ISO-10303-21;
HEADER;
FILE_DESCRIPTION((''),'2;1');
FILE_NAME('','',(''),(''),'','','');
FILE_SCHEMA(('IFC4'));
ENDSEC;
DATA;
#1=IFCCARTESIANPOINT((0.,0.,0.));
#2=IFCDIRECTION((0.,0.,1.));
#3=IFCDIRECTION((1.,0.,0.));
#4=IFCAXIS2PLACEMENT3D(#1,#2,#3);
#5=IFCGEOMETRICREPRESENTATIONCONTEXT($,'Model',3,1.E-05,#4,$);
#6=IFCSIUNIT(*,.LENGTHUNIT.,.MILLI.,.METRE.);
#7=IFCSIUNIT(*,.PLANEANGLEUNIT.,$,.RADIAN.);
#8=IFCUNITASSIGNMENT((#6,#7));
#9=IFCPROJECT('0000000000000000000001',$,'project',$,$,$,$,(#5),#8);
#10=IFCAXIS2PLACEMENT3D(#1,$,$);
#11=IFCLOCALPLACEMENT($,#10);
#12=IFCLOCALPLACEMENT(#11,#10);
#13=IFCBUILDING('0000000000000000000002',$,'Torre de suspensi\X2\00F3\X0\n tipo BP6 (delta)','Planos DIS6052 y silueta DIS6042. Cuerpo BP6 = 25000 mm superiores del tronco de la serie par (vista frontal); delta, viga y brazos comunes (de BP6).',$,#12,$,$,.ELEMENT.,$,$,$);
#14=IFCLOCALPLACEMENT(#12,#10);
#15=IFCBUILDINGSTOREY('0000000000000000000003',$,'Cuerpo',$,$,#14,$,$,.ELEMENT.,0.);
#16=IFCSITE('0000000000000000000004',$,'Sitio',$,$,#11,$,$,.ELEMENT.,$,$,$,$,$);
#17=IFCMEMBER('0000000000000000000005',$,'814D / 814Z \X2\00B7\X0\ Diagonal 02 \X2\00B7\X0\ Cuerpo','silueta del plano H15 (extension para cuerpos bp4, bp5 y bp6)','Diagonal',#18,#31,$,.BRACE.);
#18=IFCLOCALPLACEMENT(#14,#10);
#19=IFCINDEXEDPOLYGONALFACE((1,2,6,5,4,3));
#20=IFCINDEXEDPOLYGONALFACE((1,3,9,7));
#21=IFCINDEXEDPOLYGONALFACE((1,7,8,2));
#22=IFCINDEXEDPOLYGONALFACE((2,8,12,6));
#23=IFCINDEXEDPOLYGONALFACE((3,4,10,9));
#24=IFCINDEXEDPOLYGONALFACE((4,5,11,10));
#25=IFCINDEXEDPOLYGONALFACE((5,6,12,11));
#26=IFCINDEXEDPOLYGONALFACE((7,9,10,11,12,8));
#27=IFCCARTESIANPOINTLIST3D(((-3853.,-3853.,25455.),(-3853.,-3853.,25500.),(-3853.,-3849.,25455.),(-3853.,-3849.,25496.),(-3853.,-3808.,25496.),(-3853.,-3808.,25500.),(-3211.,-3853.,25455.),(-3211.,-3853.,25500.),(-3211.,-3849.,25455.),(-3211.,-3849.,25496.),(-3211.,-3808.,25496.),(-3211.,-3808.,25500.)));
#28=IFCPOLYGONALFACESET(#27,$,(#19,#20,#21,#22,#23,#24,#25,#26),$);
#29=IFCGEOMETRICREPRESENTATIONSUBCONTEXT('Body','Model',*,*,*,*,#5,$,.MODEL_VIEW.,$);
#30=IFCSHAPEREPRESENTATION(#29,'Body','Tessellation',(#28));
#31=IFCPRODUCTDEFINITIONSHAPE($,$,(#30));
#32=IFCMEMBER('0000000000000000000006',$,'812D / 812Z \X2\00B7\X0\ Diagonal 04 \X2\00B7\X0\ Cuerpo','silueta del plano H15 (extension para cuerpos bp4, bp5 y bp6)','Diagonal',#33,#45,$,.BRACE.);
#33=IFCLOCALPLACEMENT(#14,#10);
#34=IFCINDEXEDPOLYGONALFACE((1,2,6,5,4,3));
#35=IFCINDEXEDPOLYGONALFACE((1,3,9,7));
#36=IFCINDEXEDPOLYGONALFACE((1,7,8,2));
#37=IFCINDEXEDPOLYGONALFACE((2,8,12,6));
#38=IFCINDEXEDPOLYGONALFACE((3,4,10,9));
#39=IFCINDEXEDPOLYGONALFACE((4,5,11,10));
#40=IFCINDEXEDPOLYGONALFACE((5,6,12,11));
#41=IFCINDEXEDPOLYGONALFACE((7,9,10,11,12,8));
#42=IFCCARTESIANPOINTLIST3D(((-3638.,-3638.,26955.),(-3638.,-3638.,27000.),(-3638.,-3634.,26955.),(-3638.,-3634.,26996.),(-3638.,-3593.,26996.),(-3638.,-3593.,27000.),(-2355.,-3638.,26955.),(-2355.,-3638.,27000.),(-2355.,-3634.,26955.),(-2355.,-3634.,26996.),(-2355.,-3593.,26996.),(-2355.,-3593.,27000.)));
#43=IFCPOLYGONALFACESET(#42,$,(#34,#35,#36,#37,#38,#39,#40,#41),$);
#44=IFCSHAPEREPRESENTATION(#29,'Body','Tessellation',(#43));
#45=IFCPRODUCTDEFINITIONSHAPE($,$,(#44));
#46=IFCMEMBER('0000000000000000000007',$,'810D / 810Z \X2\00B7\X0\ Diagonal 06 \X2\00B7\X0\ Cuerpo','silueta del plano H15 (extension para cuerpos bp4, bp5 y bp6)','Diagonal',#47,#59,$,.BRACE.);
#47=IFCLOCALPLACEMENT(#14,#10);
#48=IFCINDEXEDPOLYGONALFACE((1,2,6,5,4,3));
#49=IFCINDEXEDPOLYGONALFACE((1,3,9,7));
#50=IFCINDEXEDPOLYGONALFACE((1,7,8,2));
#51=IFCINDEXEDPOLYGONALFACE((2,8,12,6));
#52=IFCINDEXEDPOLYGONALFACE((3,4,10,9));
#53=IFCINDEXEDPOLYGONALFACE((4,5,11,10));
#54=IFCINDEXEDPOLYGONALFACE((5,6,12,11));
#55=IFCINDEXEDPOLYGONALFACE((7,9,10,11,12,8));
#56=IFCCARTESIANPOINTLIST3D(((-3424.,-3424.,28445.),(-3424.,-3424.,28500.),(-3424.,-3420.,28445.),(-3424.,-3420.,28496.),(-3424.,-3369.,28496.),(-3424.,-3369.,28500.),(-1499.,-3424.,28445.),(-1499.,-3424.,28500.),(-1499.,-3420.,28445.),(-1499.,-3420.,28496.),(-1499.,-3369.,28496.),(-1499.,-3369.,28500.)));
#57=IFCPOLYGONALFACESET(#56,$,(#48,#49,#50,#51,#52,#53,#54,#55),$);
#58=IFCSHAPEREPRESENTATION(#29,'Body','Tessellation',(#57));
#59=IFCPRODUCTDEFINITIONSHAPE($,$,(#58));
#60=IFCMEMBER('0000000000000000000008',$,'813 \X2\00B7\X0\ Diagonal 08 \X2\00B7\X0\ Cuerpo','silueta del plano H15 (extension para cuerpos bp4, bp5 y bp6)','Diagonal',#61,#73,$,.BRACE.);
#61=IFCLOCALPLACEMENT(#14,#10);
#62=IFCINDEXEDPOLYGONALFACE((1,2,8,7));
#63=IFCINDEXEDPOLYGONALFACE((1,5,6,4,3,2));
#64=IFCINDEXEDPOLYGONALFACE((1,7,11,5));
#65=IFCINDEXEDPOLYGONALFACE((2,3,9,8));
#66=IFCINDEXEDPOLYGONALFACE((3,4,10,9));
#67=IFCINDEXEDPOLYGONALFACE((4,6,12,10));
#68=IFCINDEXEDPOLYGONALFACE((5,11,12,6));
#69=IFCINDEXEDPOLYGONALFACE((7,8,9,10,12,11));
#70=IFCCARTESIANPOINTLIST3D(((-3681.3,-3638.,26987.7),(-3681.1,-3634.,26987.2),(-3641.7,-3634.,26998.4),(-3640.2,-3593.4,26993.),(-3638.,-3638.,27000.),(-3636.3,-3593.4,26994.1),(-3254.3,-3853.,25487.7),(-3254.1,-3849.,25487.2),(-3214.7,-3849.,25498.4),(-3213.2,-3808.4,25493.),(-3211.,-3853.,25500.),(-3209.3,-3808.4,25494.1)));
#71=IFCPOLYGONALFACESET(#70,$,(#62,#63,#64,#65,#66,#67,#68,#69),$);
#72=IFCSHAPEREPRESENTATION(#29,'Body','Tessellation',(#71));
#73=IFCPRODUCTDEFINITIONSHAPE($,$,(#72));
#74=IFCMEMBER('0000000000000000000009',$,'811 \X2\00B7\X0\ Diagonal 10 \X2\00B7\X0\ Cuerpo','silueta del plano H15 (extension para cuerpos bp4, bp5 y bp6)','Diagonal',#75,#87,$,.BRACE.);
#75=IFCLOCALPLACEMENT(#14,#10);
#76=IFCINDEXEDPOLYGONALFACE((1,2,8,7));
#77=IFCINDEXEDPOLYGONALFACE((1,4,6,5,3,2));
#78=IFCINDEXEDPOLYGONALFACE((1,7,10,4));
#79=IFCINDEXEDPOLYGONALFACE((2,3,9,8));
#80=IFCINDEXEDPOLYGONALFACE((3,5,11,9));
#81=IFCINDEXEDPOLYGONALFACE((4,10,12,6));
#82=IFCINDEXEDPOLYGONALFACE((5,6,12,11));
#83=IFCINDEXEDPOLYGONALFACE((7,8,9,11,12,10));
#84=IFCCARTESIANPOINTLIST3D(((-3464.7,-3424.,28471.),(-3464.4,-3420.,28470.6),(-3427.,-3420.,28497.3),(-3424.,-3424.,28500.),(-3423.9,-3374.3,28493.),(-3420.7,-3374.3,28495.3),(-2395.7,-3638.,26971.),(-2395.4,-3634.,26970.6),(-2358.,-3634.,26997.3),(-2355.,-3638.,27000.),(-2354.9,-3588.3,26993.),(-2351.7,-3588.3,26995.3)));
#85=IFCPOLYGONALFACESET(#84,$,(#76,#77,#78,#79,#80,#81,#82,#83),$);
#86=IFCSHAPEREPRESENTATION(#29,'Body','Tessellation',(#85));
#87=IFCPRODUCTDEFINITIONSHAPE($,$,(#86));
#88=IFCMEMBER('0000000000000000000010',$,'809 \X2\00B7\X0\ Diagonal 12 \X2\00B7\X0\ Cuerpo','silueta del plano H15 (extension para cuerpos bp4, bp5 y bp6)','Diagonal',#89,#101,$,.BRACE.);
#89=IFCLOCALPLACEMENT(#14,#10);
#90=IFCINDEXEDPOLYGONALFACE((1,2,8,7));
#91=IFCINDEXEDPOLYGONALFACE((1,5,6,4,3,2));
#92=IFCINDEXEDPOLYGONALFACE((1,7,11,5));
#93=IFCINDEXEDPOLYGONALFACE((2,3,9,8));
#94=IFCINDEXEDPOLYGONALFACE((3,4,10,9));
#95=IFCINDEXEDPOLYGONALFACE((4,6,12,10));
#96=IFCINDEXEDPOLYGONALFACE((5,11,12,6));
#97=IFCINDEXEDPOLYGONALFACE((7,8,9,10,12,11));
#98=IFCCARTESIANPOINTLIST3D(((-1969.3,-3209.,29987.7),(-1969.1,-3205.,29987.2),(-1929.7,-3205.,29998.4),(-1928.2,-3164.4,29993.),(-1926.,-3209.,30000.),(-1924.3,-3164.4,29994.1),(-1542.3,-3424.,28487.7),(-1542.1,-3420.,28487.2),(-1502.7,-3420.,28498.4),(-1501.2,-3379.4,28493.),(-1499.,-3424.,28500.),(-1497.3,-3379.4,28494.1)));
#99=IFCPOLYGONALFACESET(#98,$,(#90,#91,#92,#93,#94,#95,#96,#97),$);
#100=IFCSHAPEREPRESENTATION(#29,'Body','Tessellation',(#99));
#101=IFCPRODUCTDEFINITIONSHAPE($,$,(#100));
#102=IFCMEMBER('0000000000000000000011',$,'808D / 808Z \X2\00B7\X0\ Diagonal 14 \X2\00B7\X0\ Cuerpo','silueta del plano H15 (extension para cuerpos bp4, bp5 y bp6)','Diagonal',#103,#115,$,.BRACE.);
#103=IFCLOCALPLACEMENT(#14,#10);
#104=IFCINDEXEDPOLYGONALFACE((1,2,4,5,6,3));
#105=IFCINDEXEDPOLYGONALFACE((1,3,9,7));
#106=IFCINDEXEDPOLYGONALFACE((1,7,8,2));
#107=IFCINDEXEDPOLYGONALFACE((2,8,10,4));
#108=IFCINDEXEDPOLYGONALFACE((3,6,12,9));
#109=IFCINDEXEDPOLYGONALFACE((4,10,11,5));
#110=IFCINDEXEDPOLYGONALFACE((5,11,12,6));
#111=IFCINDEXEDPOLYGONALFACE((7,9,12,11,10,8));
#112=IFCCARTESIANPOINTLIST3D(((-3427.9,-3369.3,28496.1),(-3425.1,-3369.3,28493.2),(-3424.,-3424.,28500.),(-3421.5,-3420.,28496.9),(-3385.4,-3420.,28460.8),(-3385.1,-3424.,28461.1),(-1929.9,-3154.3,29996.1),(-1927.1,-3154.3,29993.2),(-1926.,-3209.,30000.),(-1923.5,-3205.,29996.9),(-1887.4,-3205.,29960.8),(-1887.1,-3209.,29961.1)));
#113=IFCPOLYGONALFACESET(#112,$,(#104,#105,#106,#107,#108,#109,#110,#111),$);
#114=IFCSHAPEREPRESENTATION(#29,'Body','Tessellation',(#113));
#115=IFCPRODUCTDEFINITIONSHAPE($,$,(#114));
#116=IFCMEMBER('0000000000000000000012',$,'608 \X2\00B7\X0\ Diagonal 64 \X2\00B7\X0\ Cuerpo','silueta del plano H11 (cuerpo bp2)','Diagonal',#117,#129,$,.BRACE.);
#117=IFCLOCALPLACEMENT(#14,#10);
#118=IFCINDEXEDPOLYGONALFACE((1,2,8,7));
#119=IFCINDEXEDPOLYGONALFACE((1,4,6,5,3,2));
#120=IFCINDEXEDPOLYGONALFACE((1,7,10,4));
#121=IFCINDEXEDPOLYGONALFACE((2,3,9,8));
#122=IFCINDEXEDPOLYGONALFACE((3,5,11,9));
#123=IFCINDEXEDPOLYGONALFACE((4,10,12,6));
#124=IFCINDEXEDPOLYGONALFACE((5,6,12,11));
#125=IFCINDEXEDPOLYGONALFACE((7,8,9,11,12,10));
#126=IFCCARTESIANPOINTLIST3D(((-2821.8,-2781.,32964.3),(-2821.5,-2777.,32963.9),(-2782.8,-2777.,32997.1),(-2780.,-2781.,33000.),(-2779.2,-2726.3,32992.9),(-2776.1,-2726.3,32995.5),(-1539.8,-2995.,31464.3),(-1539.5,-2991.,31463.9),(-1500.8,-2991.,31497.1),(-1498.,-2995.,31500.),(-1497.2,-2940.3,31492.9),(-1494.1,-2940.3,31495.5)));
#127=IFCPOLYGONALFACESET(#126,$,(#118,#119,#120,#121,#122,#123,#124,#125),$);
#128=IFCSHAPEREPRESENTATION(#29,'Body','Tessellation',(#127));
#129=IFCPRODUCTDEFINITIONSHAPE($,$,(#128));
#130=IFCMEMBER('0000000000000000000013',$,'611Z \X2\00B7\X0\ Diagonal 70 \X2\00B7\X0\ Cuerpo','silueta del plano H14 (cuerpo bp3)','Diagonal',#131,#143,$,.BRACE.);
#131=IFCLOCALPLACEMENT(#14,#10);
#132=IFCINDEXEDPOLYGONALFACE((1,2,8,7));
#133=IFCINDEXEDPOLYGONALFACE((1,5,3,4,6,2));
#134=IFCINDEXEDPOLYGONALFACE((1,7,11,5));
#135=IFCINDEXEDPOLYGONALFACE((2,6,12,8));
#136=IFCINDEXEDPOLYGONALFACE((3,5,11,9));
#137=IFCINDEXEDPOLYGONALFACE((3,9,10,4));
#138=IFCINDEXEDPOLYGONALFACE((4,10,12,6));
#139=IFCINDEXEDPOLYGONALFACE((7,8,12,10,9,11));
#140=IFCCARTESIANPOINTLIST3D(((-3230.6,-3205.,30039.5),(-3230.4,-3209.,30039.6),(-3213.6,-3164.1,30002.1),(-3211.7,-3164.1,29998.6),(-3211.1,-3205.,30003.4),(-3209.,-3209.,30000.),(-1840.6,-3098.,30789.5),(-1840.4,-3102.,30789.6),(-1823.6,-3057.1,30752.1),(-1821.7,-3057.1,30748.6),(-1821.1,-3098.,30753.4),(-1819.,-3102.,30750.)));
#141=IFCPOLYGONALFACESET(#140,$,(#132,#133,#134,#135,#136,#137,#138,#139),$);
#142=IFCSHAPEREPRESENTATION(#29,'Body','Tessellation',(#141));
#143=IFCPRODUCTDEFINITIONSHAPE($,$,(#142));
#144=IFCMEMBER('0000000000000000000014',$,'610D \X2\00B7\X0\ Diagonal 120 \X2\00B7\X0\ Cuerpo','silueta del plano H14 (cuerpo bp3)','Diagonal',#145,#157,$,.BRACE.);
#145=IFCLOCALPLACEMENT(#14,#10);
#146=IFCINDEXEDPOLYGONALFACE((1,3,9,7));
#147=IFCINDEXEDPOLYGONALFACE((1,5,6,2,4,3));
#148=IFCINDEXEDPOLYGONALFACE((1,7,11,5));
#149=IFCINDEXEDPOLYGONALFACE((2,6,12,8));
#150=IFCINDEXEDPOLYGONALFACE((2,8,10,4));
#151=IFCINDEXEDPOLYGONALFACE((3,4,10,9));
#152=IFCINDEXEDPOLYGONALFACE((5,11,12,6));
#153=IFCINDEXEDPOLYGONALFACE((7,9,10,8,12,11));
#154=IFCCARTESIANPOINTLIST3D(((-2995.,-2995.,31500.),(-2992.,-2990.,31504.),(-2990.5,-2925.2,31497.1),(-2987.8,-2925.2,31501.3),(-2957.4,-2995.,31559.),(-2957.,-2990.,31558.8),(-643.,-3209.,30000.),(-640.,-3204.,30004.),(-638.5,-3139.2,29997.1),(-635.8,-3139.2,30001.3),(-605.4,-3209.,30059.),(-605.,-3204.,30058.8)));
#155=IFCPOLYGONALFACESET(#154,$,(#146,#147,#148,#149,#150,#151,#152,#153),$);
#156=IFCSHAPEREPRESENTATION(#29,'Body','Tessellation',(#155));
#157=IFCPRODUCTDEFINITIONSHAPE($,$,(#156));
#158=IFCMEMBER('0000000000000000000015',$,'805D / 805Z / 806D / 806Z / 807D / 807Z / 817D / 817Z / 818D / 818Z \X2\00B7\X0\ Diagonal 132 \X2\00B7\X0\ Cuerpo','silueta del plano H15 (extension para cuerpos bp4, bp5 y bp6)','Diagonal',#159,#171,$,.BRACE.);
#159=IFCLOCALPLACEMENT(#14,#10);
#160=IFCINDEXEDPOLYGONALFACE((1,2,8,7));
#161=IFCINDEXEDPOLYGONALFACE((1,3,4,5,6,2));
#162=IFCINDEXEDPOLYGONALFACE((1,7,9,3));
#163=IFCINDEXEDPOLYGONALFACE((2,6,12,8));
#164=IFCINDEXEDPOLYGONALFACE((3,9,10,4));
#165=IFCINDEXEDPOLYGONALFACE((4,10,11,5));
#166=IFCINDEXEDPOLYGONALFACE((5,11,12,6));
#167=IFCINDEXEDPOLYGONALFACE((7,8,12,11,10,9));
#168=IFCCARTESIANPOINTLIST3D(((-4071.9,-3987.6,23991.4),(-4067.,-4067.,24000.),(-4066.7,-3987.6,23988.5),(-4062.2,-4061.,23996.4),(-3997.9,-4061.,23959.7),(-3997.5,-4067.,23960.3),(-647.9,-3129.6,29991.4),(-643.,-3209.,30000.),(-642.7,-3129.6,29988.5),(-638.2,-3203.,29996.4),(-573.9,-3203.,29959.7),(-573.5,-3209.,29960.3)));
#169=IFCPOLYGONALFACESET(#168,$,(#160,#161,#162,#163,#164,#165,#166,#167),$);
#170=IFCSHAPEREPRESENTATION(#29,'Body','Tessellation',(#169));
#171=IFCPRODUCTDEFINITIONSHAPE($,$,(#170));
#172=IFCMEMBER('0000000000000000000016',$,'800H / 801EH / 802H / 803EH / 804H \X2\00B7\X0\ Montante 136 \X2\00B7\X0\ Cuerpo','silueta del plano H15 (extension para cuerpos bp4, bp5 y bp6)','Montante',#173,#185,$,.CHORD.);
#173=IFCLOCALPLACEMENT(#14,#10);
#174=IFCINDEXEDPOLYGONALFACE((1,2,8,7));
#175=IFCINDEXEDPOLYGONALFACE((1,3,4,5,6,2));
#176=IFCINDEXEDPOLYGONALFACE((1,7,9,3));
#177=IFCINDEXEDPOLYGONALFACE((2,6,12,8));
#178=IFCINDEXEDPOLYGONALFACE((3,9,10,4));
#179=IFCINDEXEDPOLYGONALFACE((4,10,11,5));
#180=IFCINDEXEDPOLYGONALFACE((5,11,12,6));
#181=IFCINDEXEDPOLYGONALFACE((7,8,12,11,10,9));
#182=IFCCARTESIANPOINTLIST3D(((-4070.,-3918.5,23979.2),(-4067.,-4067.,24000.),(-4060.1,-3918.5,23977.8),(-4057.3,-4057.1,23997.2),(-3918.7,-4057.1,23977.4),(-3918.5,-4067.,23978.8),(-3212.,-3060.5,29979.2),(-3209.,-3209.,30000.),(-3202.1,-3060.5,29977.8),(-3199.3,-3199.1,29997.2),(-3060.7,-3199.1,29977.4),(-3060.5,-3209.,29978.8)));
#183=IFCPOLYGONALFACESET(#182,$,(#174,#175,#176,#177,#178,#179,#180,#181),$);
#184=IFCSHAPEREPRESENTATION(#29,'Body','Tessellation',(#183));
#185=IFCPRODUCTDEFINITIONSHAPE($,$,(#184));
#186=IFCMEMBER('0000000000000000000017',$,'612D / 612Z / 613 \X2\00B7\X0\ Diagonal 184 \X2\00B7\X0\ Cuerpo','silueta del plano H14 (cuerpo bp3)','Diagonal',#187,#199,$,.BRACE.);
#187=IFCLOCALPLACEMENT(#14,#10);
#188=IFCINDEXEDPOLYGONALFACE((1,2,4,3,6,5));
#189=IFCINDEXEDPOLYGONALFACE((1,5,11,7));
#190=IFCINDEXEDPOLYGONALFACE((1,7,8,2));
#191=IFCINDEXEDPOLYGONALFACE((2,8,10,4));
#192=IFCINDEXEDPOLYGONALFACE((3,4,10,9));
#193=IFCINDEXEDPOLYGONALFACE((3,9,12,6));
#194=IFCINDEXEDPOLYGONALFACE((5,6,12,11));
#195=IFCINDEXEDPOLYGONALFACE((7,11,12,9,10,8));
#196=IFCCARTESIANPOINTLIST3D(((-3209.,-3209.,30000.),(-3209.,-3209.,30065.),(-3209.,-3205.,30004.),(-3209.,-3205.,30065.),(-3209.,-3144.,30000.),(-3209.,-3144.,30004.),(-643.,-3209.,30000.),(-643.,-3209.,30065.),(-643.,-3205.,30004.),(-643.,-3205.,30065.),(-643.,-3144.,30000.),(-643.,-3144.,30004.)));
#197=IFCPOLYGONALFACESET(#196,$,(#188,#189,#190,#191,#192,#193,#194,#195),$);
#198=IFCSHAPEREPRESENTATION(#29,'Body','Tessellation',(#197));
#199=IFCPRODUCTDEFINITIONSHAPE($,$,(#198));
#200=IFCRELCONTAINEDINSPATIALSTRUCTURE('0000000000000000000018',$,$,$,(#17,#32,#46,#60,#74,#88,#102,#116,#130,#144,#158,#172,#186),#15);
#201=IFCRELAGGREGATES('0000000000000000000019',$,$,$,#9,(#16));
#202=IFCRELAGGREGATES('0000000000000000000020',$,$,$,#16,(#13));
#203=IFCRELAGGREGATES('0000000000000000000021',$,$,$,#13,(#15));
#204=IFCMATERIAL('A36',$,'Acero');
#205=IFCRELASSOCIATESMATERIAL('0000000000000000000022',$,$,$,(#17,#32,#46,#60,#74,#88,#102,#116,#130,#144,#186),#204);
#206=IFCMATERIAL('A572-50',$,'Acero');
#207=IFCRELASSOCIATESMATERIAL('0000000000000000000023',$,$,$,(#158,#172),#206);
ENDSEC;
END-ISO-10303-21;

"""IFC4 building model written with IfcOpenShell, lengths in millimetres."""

from ifc_helpers import new_model, si_unit, frame, frame_2d, origin, origin_with_axes, place, context, subcontext, project, spatial, l_section, extrude, material, element, save


model = new_model("IFC4")

# Units and contexts
model_context = context("Model", 3, precision=1e-05, world=origin_with_axes())
body_context = subcontext(model_context, "Body", "Model", "MODEL_VIEW")
ifc_project = project(units=[si_unit("LENGTHUNIT", "METRE", prefix="MILLI"), si_unit("PLANEANGLEUNIT", "RADIAN")], contexts=[model_context])

# Site, building, storey
site_placement = place(None, origin())
site = spatial("IfcSite", under=ifc_project, at=site_placement, Name="Sitio", CompositionType="ELEMENT")
building_placement = place(site_placement, origin())
building = spatial("IfcBuilding", under=site, at=building_placement, Name="Torre de suspensión tipo BP6 (delta)", Description="Planos DIS6052 y silueta DIS6042. Cuerpo BP6 = 25000 mm superiores del tronco de la serie par (vista frontal); delta, viga y brazos comunes (de BP6).", CompositionType="ELEMENT")
storey_placement = place(building_placement, origin())
storey = spatial("IfcBuildingStorey", under=building, at=storey_placement, Name="Cuerpo", CompositionType="ELEMENT", Elevation=0.0)

# Members
ifc_material_1 = material(Name="A36", Category="Acero")
member_1_placement = place(storey_placement, frame((-3211.0, -3853.0, 25500.0), z_axis=(-1.0, 0.0, 0.0), x_axis=(0.0, 1.0, 0.0)))
element("IfcMember", 1, at=member_1_placement, inside=storey, material=ifc_material_1, Name="814D / 814Z · Diagonal 02 · Cuerpo", Description="silueta del plano H15 (extension para cuerpos bp4, bp5 y bp6)", ObjectType="Diagonal", PredefinedType="BRACE", context=body_context, shape_type="SweptSolid", body=[
    extrude(l_section(Depth=45.0, Width=45.0, Thickness=4.0, at=frame_2d((22.5, 22.5))), None, (0.0, 0.0, 1.0), 642.0),
])
member_2_placement = place(storey_placement, frame((-2355.0, -3638.0, 27000.0), z_axis=(-1.0, 0.0, 0.0), x_axis=(0.0, 1.0, 0.0)))
element("IfcMember", 2, at=member_2_placement, inside=storey, material=ifc_material_1, Name="812D / 812Z · Diagonal 04 · Cuerpo", Description="silueta del plano H15 (extension para cuerpos bp4, bp5 y bp6)", ObjectType="Diagonal", PredefinedType="BRACE", context=body_context, shape_type="SweptSolid", body=[
    extrude(l_section(Depth=45.0, Width=45.0, Thickness=4.0, at=frame_2d((22.5, 22.5))), None, (0.0, 0.0, 1.0), 1283.0),
])
member_3_placement = place(storey_placement, frame((-1499.0, -3424.0, 28500.0), z_axis=(-1.0, 0.0, 0.0), x_axis=(0.0, 1.0, 0.0)))
element("IfcMember", 3, at=member_3_placement, inside=storey, material=ifc_material_1, Name="810D / 810Z · Diagonal 06 · Cuerpo", Description="silueta del plano H15 (extension para cuerpos bp4, bp5 y bp6)", ObjectType="Diagonal", PredefinedType="BRACE", context=body_context, shape_type="SweptSolid", body=[
    extrude(l_section(Depth=55.0, Width=55.0, Thickness=4.0, at=frame_2d((27.5, 27.5))), None, (0.0, 0.0, 1.0), 1925.0),
])
member_4_placement = place(storey_placement, frame((-3211.0, -3853.0, 25500.0), z_axis=(-0.271224, 0.136565, 0.952779), x_axis=(0.03739, 0.990631, -0.131347)))
element("IfcMember", 4, at=member_4_placement, inside=storey, material=ifc_material_1, Name="813 · Diagonal 08 · Cuerpo", Description="silueta del plano H15 (extension para cuerpos bp4, bp5 y bp6)", ObjectType="Diagonal", PredefinedType="BRACE", context=body_context, shape_type="SweptSolid", body=[
    extrude(l_section(Depth=45.0, Width=45.0, Thickness=4.0, at=frame_2d((22.5, 22.5))), None, (0.0, 0.0, 1.0), 1574.3),
])
member_5_placement = place(storey_placement, frame((-2355.0, -3638.0, 27000.0), z_axis=(-0.576487, 0.115405, 0.808915), x_axis=(0.066977, 0.993318, -0.093981)))
element("IfcMember", 5, at=member_5_placement, inside=storey, material=ifc_material_1, Name="811 · Diagonal 10 · Cuerpo", Description="silueta del plano H15 (extension para cuerpos bp4, bp5 y bp6)", ObjectType="Diagonal", PredefinedType="BRACE", context=body_context, shape_type="SweptSolid", body=[
    extrude(l_section(Depth=50.0, Width=50.0, Thickness=4.0, at=frame_2d((25.0, 25.0))), None, (0.0, 0.0, 1.0), 1854.3),
])
member_6_placement = place(storey_placement, frame((-1499.0, -3424.0, 28500.0), z_axis=(-0.271224, 0.136565, 0.952779), x_axis=(0.03739, 0.990631, -0.131347)))
element("IfcMember", 6, at=member_6_placement, inside=storey, material=ifc_material_1, Name="809 · Diagonal 12 · Cuerpo", Description="silueta del plano H15 (extension para cuerpos bp4, bp5 y bp6)", ObjectType="Diagonal", PredefinedType="BRACE", context=body_context, shape_type="SweptSolid", body=[
    extrude(l_section(Depth=45.0, Width=45.0, Thickness=4.0, at=frame_2d((22.5, 22.5))), None, (0.0, 0.0, 1.0), 1574.3),
])
member_7_placement = place(storey_placement, frame((-1926.0, -3209.0, 30000.0), z_axis=(-0.703029, -0.100902, -0.703967), x_axis=(-0.071301, 0.994896, -0.071396)))
element("IfcMember", 7, at=member_7_placement, inside=storey, material=ifc_material_1, Name="808D / 808Z · Diagonal 14 · Cuerpo", Description="silueta del plano H15 (extension para cuerpos bp4, bp5 y bp6)", ObjectType="Diagonal", PredefinedType="BRACE", context=body_context, shape_type="SweptSolid", body=[
    extrude(l_section(Depth=55.0, Width=55.0, Thickness=4.0, at=frame_2d((27.5, 27.5))), None, (0.0, 0.0, 1.0), 2130.8),
])
member_8_placement = place(storey_placement, frame((-1498.0, -2995.0, 31500.0), z_axis=(-0.645918, 0.107821, 0.755754), x_axis=(0.070052, 0.99417, -0.081964)))
element("IfcMember", 8, at=member_8_placement, inside=storey, material=ifc_material_1, Name="608 · Diagonal 64 · Cuerpo", Description="silueta del plano H11 (cuerpo bp2)", ObjectType="Diagonal", PredefinedType="BRACE", context=body_context, shape_type="SweptSolid", body=[
    extrude(l_section(Depth=55.0, Width=55.0, Thickness=4.0, at=frame_2d((27.5, 27.5))), None, (0.0, 0.0, 1.0), 1984.8),
])
member_9_placement = place(storey_placement, frame((-3209.0, -3209.0, 30000.0), z_axis=(0.878052, 0.067591, 0.473769), x_axis=(-0.059484, 0.997713, -0.032096)))
element("IfcMember", 9, at=member_9_placement, inside=storey, material=ifc_material_1, Name="611Z · Diagonal 70 · Cuerpo", Description="silueta del plano H14 (cuerpo bp3)", ObjectType="Diagonal", PredefinedType="BRACE", context=body_context, shape_type="SweptSolid", body=[
    extrude(l_section(Depth=45.0, Width=45.0, Thickness=4.0, at=frame_2d((22.5, 22.5))), None, (0.0, 0.0, 1.0), 1583.1),
])
member_10_placement = place(storey_placement, frame((-2995.0, -2995.0, 31500.0), z_axis=(0.84066, -0.076489, -0.536135), x_axis=(0.06449, 0.99707, -0.041129)))
element("IfcMember", 10, at=member_10_placement, inside=storey, material=ifc_material_1, Name="610D · Diagonal 120 · Cuerpo", Description="silueta del plano H14 (cuerpo bp3)", ObjectType="Diagonal", PredefinedType="BRACE", context=body_context, shape_type="SweptSolid", body=[
    extrude(l_section(Depth=70.0, Width=70.0, Thickness=5.0, at=frame_2d((35.0, 35.0))), None, (0.0, 0.0, 1.0), 2797.8),
])
ifc_material_2 = material(Name="A572-50", Category="Acero")
member_11_placement = place(storey_placement, frame((-643.0, -3209.0, 30000.0), z_axis=(-0.491861, -0.123253, -0.861906), x_axis=(-0.061089, 0.992375, -0.107048)))
element("IfcMember", 11, at=member_11_placement, inside=storey, material=ifc_material_2, Name="805D / 805Z / 806D / 806Z / 807D / 807Z / 817D / 817Z / 818D / 818Z · Diagonal 132 · Cuerpo", Description="silueta del plano H15 (extension para cuerpos bp4, bp5 y bp6)", ObjectType="Diagonal", PredefinedType="BRACE", context=body_context, shape_type="SweptSolid", body=[
    extrude(l_section(Depth=80.0, Width=80.0, Thickness=6.0, at=frame_2d((40.0, 40.0))), None, (0.0, 0.0, 1.0), 6961.3),
])
member_12_placement = place(storey_placement, frame((-3209.0, -3209.0, 30000.0), z_axis=(-0.140163, -0.140163, -0.980158), x_axis=(-0.019841, 0.990129, -0.138751)))
element("IfcMember", 12, at=member_12_placement, inside=storey, material=ifc_material_2, Name="800H / 801EH / 802H / 803EH / 804H · Montante 136 · Cuerpo", Description="silueta del plano H15 (extension para cuerpos bp4, bp5 y bp6)", ObjectType="Montante", PredefinedType="CHORD", context=body_context, shape_type="SweptSolid", body=[
    extrude(l_section(Depth=150.0, Width=150.0, Thickness=10.0, at=frame_2d((75.0, 75.0))), None, (0.0, 0.0, 1.0), 6121.5),
])
member_13_placement = place(storey_placement, frame((-3209.0, -3209.0, 30000.0), z_axis=(1.0, 0.0, 0.0), x_axis=(0.0, 1.0, 0.0)))
element("IfcMember", 13, at=member_13_placement, inside=storey, material=ifc_material_1, Name="612D / 612Z / 613 · Diagonal 184 · Cuerpo", Description="silueta del plano H14 (cuerpo bp3)", ObjectType="Diagonal", PredefinedType="BRACE", context=body_context, shape_type="SweptSolid", body=[
    extrude(l_section(Depth=65.0, Width=65.0, Thickness=4.0, at=frame_2d((32.5, 32.5))), None, (0.0, 0.0, 1.0), 2566.0),
])

save(model, "model.ifc")
